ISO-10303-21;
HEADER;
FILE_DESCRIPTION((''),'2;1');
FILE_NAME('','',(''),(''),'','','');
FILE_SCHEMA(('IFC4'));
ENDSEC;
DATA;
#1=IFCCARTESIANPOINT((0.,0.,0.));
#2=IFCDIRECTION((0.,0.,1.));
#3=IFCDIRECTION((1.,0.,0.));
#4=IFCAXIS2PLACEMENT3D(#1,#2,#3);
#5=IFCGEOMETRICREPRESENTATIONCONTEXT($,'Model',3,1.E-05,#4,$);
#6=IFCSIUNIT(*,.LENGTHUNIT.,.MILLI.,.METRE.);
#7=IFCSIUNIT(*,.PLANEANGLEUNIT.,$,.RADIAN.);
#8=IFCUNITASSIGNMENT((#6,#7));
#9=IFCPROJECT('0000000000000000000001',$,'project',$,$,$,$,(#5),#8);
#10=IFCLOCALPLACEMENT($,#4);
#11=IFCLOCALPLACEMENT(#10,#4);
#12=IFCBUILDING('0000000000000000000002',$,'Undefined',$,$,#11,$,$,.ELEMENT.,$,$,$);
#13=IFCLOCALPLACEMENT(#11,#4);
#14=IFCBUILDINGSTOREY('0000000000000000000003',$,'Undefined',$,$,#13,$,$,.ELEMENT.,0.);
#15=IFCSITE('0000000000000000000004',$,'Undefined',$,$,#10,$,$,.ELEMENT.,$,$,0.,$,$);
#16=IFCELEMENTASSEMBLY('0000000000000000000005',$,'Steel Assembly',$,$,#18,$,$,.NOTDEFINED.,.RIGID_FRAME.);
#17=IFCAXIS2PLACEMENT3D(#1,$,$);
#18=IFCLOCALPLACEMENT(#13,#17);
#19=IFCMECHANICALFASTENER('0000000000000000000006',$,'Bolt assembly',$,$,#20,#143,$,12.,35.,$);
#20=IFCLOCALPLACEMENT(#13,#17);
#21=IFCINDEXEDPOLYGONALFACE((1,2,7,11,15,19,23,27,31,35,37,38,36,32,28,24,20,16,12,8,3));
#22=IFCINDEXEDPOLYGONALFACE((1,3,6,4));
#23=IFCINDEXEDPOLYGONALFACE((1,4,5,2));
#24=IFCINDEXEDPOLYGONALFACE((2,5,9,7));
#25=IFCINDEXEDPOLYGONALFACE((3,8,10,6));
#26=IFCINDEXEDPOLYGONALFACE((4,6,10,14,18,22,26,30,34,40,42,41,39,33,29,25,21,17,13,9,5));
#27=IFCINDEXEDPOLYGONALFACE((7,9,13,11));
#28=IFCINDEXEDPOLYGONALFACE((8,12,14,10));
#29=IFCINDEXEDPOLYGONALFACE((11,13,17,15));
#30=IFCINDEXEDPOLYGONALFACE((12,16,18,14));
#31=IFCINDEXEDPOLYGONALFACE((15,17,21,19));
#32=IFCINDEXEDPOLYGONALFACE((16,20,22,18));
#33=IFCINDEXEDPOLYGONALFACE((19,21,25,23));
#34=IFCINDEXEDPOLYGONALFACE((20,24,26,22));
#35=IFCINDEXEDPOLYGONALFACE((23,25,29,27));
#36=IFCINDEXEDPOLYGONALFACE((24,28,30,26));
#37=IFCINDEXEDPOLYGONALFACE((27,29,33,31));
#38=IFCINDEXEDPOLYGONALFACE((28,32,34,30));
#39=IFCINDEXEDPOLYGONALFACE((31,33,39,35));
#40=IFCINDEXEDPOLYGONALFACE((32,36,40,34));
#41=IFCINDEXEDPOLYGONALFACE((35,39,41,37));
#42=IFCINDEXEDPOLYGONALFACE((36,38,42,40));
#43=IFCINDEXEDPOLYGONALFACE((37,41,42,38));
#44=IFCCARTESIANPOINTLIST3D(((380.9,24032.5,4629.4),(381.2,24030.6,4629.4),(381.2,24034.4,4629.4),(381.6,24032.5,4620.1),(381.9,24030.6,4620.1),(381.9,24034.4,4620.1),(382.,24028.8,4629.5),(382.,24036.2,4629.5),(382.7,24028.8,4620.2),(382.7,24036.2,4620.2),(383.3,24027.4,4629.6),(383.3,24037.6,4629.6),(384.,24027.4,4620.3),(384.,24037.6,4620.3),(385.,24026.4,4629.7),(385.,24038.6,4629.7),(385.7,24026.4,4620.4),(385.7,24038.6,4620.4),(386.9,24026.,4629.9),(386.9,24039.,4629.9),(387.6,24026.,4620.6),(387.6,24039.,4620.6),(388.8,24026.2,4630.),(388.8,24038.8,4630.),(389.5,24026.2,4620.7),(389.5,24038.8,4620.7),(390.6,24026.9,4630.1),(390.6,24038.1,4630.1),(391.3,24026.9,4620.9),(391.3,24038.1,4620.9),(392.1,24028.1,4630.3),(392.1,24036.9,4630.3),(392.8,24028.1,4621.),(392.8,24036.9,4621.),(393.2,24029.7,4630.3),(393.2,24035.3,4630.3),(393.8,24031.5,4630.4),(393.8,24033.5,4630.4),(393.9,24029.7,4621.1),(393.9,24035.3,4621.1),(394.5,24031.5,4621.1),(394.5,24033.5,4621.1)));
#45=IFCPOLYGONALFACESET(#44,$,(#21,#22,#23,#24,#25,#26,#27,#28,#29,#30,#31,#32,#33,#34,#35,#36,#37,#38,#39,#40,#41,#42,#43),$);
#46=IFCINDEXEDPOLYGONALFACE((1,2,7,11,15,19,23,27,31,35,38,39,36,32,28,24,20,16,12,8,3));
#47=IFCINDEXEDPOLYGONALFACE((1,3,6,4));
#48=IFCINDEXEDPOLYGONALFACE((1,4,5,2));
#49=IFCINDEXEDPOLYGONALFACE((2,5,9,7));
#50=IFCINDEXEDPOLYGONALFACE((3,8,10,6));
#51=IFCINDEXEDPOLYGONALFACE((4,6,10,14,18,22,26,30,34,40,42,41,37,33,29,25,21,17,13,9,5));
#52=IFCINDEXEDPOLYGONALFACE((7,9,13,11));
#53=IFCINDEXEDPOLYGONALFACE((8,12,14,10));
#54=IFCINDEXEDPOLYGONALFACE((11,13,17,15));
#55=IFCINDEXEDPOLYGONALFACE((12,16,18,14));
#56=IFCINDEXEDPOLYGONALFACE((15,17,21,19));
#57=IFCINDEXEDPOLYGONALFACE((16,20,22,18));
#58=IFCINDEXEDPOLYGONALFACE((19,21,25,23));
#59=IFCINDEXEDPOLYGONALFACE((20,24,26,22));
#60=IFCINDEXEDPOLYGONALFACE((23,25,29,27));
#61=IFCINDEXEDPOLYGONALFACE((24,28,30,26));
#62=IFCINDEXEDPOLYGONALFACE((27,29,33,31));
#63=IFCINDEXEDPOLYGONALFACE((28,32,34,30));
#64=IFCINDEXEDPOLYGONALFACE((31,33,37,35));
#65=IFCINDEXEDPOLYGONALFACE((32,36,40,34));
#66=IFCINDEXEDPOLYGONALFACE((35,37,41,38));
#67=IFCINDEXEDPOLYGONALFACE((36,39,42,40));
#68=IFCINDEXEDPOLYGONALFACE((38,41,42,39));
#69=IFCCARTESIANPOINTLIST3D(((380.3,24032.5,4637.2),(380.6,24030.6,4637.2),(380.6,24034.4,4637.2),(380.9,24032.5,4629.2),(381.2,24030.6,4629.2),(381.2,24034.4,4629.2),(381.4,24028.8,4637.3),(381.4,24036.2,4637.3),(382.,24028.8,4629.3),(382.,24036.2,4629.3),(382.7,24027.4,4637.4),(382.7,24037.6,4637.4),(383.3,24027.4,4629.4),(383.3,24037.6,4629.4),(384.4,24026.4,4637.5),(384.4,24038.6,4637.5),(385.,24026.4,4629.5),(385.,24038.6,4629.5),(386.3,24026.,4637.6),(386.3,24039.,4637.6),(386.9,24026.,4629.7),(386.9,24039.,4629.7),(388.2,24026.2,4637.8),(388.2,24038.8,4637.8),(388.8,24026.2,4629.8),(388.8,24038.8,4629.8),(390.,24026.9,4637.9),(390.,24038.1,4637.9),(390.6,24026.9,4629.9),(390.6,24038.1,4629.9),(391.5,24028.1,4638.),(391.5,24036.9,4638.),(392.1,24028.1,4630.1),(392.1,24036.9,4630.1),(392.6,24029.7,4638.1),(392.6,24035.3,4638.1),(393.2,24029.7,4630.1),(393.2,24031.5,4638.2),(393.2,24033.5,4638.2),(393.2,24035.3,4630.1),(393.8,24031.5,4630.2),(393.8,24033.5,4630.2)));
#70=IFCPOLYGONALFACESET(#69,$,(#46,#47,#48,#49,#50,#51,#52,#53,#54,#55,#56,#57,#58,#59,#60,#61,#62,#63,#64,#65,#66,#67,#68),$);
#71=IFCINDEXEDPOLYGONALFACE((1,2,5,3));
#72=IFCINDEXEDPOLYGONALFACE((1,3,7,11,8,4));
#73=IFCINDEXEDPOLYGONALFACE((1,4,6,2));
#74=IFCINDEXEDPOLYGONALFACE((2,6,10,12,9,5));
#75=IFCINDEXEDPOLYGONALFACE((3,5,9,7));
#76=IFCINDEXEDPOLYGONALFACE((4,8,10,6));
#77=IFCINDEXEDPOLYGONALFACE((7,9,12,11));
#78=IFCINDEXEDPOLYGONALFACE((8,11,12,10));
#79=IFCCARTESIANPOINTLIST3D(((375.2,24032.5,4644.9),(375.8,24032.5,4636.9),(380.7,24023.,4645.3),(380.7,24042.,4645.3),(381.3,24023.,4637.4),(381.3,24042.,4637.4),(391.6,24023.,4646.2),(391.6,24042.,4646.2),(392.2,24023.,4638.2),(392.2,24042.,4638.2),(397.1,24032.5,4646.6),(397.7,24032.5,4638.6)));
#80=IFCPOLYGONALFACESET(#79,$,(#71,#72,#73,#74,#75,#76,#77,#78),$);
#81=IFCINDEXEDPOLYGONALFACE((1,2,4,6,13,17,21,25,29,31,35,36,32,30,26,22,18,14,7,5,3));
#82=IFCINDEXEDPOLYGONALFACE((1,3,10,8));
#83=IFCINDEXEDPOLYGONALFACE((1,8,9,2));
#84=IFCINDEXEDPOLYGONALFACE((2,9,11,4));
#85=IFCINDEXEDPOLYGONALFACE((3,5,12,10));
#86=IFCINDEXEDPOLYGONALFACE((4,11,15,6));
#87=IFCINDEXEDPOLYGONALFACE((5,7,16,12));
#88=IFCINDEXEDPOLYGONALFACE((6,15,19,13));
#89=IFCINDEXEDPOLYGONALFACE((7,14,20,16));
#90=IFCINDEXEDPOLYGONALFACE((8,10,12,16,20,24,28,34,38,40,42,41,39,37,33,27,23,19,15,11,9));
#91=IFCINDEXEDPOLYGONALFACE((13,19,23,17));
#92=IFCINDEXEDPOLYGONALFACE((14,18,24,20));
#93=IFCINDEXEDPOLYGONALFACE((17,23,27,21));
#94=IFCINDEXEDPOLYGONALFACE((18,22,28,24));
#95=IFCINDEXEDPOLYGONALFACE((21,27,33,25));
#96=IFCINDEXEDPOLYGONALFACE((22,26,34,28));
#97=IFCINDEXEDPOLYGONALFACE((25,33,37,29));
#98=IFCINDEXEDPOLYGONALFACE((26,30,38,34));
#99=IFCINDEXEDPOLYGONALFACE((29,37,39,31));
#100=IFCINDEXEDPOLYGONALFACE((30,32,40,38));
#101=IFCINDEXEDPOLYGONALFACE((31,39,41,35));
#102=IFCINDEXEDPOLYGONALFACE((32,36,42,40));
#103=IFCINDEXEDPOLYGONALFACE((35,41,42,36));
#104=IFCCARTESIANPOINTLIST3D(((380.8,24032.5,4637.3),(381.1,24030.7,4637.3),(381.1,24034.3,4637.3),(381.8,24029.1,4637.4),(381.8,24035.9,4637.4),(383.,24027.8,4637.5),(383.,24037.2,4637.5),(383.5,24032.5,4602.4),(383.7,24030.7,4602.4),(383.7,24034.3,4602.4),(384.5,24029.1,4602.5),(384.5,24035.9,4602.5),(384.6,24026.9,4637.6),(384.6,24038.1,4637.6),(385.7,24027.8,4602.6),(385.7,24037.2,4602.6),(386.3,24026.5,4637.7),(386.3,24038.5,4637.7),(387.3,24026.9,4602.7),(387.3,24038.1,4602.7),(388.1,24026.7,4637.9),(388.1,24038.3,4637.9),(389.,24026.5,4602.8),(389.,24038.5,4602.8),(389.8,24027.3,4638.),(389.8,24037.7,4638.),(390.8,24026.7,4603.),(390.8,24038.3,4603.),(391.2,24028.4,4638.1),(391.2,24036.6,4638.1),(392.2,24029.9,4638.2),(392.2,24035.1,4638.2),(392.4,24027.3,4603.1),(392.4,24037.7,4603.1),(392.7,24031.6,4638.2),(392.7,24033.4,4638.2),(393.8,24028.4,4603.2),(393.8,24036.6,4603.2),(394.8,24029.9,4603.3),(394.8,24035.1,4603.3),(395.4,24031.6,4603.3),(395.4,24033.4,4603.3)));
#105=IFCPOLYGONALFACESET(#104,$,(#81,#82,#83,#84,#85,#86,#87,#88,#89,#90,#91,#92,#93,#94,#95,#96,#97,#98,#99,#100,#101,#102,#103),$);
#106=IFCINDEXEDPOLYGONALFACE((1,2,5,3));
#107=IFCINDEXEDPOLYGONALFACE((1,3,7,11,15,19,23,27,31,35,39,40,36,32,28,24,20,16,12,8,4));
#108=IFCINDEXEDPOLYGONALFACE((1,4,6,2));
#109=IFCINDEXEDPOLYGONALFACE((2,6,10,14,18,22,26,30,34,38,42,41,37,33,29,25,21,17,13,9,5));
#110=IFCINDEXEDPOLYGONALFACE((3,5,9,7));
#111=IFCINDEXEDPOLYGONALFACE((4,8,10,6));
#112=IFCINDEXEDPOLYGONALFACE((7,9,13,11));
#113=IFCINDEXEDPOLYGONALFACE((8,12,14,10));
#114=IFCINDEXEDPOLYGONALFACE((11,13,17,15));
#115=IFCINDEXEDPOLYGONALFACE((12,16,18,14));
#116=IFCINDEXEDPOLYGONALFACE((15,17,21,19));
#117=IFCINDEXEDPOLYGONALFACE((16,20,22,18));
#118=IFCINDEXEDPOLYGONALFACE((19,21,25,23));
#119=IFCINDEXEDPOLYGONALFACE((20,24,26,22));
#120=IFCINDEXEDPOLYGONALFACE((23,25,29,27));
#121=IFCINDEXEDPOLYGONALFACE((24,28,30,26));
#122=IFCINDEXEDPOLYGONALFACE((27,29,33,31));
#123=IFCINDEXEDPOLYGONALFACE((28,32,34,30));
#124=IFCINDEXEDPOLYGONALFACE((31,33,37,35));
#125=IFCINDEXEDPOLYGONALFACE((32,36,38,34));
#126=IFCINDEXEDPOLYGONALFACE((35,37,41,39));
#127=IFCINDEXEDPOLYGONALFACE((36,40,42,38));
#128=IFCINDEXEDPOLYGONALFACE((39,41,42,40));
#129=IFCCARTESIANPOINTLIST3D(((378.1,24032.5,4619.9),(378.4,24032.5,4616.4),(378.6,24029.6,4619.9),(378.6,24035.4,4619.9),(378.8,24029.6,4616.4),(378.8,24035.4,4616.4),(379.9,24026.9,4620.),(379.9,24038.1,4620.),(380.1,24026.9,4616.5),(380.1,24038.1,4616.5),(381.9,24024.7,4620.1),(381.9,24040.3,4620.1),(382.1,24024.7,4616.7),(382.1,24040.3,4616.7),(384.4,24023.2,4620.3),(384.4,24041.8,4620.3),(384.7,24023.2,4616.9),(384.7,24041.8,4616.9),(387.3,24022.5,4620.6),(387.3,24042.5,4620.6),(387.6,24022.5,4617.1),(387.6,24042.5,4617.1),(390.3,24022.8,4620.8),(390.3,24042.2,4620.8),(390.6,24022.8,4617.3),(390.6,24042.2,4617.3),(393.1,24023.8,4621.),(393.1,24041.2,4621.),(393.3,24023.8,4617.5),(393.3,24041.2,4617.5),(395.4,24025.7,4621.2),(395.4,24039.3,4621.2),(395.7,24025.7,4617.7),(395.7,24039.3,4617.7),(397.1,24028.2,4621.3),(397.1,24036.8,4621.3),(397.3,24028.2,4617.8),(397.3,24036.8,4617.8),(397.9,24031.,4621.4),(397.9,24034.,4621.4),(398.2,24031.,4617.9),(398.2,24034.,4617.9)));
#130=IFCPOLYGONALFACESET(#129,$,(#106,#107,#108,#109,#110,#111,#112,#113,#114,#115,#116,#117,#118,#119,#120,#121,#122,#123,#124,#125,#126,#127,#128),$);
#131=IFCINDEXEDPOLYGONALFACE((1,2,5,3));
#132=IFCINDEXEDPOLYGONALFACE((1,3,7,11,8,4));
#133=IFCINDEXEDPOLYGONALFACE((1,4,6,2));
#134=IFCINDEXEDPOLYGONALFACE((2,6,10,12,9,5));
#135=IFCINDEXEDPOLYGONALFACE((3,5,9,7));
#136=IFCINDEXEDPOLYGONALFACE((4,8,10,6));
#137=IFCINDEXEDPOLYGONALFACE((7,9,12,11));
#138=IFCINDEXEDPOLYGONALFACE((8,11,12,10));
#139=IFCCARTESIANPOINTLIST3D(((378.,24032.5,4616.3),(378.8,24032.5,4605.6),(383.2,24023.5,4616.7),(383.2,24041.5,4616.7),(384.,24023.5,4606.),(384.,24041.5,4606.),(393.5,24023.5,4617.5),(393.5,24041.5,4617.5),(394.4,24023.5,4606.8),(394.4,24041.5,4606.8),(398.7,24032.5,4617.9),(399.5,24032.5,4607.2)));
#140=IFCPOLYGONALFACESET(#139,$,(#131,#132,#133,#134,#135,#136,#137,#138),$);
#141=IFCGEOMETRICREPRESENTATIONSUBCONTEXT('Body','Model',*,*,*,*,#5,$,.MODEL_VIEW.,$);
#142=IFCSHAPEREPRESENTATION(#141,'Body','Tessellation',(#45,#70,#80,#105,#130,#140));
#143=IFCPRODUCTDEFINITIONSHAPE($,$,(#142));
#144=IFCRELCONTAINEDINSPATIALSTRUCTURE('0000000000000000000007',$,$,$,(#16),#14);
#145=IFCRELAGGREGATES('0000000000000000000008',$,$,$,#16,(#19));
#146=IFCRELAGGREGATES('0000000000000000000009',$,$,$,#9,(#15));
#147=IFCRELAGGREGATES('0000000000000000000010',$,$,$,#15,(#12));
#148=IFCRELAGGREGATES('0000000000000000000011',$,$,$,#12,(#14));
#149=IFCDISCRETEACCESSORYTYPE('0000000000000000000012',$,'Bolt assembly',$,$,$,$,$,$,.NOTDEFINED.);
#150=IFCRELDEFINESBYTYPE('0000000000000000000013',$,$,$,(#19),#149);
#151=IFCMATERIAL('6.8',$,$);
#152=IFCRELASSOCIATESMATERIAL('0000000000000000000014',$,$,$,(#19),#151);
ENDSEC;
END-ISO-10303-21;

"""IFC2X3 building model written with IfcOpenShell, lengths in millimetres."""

from ifc_helpers import new_model, si_unit, frame, origin_with_axes, origin_2d_with_axis, place, context, subcontext, project, spatial, polyline, circle, outline, extrude, source, transform, mapped, material, type_object, element, aggregate, save


model = new_model("IFC2X3")

# Units and contexts
model_context = context("Model", 3, precision=1e-05, world=origin_with_axes())
body_context = subcontext(model_context, "Body", "Model", "MODEL_VIEW")
ifc_project = project(units=[si_unit("LENGTHUNIT", "METRE", prefix="MILLI"), si_unit("PLANEANGLEUNIT", "RADIAN")], contexts=[model_context])

# Site, building, storey
site_placement = place(None, origin_with_axes())
site = spatial("IfcSite", under=ifc_project, at=site_placement, Name="Undefined", CompositionType="ELEMENT", RefElevation=0.0)
building_placement = place(site_placement, origin_with_axes())
building = spatial("IfcBuilding", under=site, at=building_placement, Name="Undefined", CompositionType="ELEMENT")
storey_placement = place(building_placement, origin_with_axes())
storey = spatial("IfcBuildingStorey", under=building, at=storey_placement, Name="Undefined", CompositionType="ELEMENT", Elevation=0.0)

# Shared definitions
ifc_material_1 = material(Name="6.8")
discrete_accessory_type_1 = type_object("IfcDiscreteAccessoryType", Name="Bolt assembly")

# Element assembly, mechanical fastener
assembly_1_placement = place(storey_placement, origin_with_axes())
assembly_1 = element("IfcElementAssembly", 1, at=assembly_1_placement, inside=storey, Name="Steel Assembly", AssemblyPlace="NOTDEFINED", PredefinedType="RIGID_FRAME")
shared_shape_1 = source(origin_with_axes(), body_context, "Body", "SweptSolid", [
    extrude(circle(Radius=6.5, at=origin_2d_with_axis()), frame((0.0, -0.1, 0.0), z_axis=(0.0, 1.0, 0.0), x_axis=(1.0, 0.0, 0.0)), (0.0, 0.0, 1.0), 9.3),
    extrude(circle(Radius=6.5, at=origin_2d_with_axis()), frame((0.0, -7.9, 0.0), z_axis=(0.0, 1.0, 0.0), x_axis=(1.0, 0.0, 0.0)), (0.0, 0.0, 1.0), 8.0),
    extrude(outline(polyline([(11.0, 0.0), (5.5, 9.5), (-5.5, 9.5), (-11.0, 0.0), (-5.5, -9.5), (5.5, -9.5), (11.0, 0.0)])), frame((0.0, -16.0, 0.0), z_axis=(0.0, 1.0, 0.0), x_axis=(1.0, 0.0, 0.0)), (0.0, 0.0, 1.0), 8.0),
    extrude(circle(Radius=6.0, at=origin_2d_with_axis()), frame((0.0, -8.0, 0.0), z_axis=(0.0, 1.0, 0.0), x_axis=(1.0, 0.0, 0.0)), (0.0, 0.0, 1.0), 35.0),
    extrude(circle(Radius=10.0, at=origin_2d_with_axis()), frame((0.0, 9.2, 0.0), z_axis=(0.0, 1.0, 0.0), x_axis=(1.0, 0.0, 0.0)), (0.0, 0.0, 1.0), 3.5),
    extrude(outline(polyline([(10.4, 0.0), (5.2, 9.0), (-5.2, 9.0), (-10.4, 0.0), (-5.2, -9.0), (5.2, -9.0), (10.4, 0.0)])), frame((0.0, 12.7, 0.0), z_axis=(0.0, 1.0, 0.0), x_axis=(1.0, 0.0, 0.0)), (0.0, 0.0, 1.0), 10.8),
])
mechanical_fastener_1_placement = place(assembly_1_placement, frame((387.4, 24032.5, 4629.8), z_axis=(0.0, -1.0, 0.0), x_axis=(-0.997054, 0.0, -0.076696)))
mechanical_fastener_1 = element("IfcMechanicalFastener", 2, at=mechanical_fastener_1_placement, type_object=discrete_accessory_type_1, material=ifc_material_1, Name="Bolt assembly", NominalDiameter=12.0, NominalLength=35.0, context=body_context, shape_type="MappedRepresentation", body=[
    mapped(shared_shape_1, transform((0.0, 0.0, 0.0))),
])
aggregate(assembly_1, [mechanical_fastener_1])

save(model, "model.ifc")
